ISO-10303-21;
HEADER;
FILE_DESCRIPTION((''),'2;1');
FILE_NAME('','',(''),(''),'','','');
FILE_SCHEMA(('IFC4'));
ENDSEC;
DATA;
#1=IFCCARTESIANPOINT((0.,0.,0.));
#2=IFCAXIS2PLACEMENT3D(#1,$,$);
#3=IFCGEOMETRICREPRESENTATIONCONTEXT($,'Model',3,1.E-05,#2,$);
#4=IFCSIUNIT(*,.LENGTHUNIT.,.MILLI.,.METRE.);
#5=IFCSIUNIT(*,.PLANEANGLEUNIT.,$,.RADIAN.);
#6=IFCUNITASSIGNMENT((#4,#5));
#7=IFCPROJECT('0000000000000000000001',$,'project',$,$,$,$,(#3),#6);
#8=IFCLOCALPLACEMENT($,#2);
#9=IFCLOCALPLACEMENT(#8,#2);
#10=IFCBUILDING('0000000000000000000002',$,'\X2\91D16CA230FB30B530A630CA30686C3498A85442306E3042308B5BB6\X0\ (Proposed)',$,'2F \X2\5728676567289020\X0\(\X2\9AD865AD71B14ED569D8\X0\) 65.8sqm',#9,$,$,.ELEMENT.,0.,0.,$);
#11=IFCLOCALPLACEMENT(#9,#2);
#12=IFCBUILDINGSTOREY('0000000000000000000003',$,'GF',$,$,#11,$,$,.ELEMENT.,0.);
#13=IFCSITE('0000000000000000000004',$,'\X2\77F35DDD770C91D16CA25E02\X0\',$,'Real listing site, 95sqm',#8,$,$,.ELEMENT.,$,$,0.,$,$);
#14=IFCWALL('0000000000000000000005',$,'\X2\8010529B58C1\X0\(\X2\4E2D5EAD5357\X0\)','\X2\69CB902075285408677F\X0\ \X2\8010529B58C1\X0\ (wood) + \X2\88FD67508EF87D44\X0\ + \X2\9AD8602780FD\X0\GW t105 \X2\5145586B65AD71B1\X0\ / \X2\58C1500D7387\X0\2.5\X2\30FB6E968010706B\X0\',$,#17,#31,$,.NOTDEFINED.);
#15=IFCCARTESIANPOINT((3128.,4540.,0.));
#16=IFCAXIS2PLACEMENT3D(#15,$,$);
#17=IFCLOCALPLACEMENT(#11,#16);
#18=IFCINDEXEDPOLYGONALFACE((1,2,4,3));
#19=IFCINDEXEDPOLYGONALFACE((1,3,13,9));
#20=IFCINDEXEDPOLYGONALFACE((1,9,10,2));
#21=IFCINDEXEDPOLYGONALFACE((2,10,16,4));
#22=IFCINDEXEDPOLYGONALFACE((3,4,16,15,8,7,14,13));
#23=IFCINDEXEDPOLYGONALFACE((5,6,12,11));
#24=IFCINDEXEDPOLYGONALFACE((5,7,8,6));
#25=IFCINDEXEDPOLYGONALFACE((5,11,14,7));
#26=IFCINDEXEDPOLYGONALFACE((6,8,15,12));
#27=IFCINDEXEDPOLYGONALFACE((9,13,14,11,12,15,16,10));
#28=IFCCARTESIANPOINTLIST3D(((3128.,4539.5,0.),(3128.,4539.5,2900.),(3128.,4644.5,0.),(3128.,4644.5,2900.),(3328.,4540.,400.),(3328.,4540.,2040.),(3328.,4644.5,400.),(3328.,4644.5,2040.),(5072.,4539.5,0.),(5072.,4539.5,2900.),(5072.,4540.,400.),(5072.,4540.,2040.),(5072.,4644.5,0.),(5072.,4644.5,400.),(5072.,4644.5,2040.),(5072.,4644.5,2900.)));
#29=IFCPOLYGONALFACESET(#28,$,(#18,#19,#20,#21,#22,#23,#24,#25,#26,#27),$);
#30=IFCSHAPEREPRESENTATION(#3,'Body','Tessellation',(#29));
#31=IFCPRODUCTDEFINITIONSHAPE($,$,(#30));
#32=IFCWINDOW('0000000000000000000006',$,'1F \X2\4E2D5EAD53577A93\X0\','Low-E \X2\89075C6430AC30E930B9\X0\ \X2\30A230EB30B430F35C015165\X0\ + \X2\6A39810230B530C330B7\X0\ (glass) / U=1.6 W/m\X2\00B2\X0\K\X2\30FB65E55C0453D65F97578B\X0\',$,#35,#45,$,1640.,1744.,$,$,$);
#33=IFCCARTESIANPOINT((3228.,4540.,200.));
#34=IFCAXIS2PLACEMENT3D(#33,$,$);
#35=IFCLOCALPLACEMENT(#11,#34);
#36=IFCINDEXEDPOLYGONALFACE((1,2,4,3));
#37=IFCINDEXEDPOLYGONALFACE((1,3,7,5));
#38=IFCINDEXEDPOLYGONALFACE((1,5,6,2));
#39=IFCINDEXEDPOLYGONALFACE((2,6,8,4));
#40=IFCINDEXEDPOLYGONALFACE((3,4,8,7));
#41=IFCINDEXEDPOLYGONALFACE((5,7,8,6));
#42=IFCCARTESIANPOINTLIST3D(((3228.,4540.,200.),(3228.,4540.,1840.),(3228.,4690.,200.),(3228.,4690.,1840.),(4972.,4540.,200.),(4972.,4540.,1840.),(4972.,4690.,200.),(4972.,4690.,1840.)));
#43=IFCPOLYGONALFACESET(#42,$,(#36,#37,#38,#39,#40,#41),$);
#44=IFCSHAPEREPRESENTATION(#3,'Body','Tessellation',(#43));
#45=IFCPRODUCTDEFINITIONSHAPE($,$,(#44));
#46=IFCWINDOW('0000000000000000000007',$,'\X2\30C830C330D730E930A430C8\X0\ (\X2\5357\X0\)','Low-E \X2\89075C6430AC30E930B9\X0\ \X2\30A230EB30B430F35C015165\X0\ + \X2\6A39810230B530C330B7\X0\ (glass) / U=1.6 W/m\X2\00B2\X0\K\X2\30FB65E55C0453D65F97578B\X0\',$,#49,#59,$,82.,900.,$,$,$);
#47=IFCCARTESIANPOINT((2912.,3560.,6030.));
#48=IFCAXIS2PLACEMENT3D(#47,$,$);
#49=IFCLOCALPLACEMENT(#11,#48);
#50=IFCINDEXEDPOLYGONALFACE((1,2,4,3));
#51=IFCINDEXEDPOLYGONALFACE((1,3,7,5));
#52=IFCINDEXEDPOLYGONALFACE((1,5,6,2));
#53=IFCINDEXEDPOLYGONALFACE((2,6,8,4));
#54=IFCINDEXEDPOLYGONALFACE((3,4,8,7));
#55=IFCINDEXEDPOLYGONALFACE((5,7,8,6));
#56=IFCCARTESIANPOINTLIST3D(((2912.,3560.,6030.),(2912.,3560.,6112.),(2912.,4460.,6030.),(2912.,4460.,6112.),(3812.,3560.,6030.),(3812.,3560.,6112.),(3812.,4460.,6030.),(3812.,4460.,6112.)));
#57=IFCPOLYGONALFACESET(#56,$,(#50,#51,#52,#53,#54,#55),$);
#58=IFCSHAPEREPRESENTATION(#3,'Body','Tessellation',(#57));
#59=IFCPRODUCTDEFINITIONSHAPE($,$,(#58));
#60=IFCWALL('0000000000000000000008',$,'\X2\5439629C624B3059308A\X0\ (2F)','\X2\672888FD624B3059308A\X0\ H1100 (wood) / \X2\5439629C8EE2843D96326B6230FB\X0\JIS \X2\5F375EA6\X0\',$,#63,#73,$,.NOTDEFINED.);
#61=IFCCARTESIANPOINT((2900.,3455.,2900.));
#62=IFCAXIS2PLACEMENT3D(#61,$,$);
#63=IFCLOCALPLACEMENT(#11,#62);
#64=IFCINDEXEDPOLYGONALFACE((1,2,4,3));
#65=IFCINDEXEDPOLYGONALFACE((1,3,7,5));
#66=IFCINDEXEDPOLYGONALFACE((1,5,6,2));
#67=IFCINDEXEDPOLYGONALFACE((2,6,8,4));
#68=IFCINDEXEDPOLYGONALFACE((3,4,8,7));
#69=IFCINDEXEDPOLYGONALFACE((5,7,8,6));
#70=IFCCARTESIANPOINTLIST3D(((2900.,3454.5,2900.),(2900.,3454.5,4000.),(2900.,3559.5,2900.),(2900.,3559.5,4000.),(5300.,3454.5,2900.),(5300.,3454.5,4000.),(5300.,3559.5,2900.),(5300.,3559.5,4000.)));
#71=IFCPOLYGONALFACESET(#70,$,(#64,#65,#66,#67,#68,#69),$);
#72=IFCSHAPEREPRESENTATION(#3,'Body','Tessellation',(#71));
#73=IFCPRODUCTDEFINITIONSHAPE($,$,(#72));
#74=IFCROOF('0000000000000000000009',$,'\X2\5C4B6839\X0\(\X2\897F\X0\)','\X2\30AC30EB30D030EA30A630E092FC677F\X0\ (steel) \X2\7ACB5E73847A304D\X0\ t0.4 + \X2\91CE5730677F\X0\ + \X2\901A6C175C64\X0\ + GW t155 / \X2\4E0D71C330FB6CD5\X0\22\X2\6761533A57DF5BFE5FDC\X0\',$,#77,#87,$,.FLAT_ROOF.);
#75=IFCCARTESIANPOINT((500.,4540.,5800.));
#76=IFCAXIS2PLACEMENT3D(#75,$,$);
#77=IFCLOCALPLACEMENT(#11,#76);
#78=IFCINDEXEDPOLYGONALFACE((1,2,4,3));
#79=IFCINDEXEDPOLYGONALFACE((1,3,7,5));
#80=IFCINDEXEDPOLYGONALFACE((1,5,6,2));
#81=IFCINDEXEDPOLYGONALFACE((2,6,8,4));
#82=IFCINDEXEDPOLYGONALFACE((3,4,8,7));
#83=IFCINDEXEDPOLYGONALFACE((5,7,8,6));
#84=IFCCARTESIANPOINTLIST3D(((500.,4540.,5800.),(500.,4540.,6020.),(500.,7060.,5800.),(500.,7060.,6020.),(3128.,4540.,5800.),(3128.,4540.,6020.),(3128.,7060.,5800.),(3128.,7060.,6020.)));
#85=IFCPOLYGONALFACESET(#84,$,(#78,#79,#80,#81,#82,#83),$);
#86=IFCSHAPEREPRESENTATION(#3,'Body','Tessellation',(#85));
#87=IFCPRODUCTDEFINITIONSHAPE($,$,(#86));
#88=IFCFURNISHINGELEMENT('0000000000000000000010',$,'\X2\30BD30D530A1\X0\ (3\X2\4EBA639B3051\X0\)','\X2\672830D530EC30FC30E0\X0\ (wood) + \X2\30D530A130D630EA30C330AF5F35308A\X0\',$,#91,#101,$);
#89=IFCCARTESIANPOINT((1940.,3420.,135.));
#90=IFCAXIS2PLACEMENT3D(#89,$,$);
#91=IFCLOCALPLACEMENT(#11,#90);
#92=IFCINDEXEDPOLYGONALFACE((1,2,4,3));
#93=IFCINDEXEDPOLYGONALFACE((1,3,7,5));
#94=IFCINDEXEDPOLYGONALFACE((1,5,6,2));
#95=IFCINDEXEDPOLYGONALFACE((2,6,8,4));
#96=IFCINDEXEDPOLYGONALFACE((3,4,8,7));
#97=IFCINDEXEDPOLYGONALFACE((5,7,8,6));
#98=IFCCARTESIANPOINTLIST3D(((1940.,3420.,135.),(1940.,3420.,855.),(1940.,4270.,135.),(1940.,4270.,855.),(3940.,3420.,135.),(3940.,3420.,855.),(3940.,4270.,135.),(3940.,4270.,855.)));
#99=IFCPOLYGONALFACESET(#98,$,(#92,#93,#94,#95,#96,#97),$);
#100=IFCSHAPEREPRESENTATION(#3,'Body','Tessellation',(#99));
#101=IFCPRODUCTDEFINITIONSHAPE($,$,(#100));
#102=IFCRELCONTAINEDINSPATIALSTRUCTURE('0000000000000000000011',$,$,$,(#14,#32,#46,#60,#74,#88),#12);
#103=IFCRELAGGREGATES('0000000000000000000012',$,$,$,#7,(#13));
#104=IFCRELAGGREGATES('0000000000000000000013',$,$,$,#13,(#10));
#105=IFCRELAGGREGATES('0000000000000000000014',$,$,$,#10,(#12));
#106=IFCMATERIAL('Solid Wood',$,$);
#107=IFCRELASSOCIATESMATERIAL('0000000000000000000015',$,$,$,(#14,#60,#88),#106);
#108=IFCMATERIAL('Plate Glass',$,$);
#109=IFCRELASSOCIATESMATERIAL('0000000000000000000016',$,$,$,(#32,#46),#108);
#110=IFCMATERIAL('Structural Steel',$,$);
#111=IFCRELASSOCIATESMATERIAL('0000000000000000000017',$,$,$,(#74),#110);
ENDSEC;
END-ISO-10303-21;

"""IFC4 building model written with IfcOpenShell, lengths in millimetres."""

from ifc_helpers import new_model, si_unit, frame, frame_2d, origin, place, context, project, spatial, rectangle, extrude, material, element, fill, save


model = new_model("IFC4")

# Units and contexts
model_context = context("Model", 3, precision=1e-05, world=origin())
ifc_project = project(units=[si_unit("LENGTHUNIT", "METRE", prefix="MILLI"), si_unit("PLANEANGLEUNIT", "RADIAN")], contexts=[model_context])

# Site, building, storey
site_placement = place(None, origin())
site = spatial("IfcSite", under=ifc_project, at=site_placement, Name="石川県金沢市", ObjectType="Real listing site, 95sqm", CompositionType="ELEMENT", RefElevation=0.0)
building_placement = place(site_placement, origin())
building = spatial("IfcBuilding", under=site, at=building_placement, Name="金沢・サウナと水風呂のある家 (Proposed)", ObjectType="2F 在来木造(高断熱仕様) 65.8sqm", CompositionType="ELEMENT", ElevationOfRefHeight=0.0, ElevationOfTerrain=0.0)
storey_placement = place(building_placement, origin())
storey = spatial("IfcBuildingStorey", under=building, at=storey_placement, Name="GF", CompositionType="ELEMENT", Elevation=0.0)

# Shared definitions
ifc_material_1 = material(Name="Solid Wood")

# Wall, opening, window
wall_1_placement = place(storey_placement, frame((3128.0, 4540.0, 0.0)))
wall_1 = element("IfcWall", 1, at=wall_1_placement, inside=storey, material=ifc_material_1, Name="耐力壁(中庭南)", Description="構造用合板 耐力壁 (wood) + 製材軸組 + 高性能GW t105 充填断熱 / 壁倍率2.5・準耐火", PredefinedType="NOTDEFINED", context=model_context, shape_type="SweptSolid", body=[
    extrude(rectangle(XDim=1944.0, YDim=105.0, at=frame_2d((972.0, 52.0))), frame((3128.0, 4540.0, 0.0)), (0.0, 0.0, 1.0), 2900.0),
])
opening_placement = place(storey_placement, frame((3228.0, 4540.0, 200.0)))
opening = element("IfcOpeningElement", 2, at=opening_placement, cuts=wall_1, PredefinedType="NOTDEFINED", context=model_context, shape_type="SweptSolid", body=[
    extrude(rectangle(XDim=1744.0, YDim=150.0, at=frame_2d((872.0, 75.0))), frame((3228.0, 4540.0, 200.0)), (0.0, 0.0, 1.0), 1640.0),
])
ifc_material_2 = material(Name="Plate Glass")
window_1_placement = place(storey_placement, frame((3228.0, 4540.0, 200.0)))
window_1 = element("IfcWindow", 3, at=window_1_placement, inside=storey, material=ifc_material_2, Name="1F 中庭南窓", Description="Low-E 複層ガラス アルゴン封入 + 樹脂サッシ (glass) / U=1.6 W/m²K・日射取得型", OverallHeight=1640.0, OverallWidth=1744.0, context=model_context, shape_type="SweptSolid", body=[
    extrude(rectangle(XDim=1744.0, YDim=150.0, at=frame_2d((872.0, 75.0))), frame((3228.0, 4540.0, 200.0)), (0.0, 0.0, 1.0), 1640.0),
])
fill(opening, window_1)

# Window
window_2_placement = place(storey_placement, frame((2912.0, 3560.0, 6030.0)))
element("IfcWindow", 4, at=window_2_placement, inside=storey, material=ifc_material_2, Name="トップライト (南)", Description="Low-E 複層ガラス アルゴン封入 + 樹脂サッシ (glass) / U=1.6 W/m²K・日射取得型", OverallHeight=82.0, OverallWidth=900.0, context=model_context, shape_type="SweptSolid", body=[
    extrude(rectangle(XDim=900.0, YDim=900.0, at=frame_2d((450.0, 450.0))), frame((2912.0, 3560.0, 6030.0)), (0.0, 0.0, 1.0), 82.0),
])

# Wall
wall_2_placement = place(storey_placement, frame((2900.0, 3455.0, 2900.0)))
element("IfcWall", 5, at=wall_2_placement, inside=storey, material=ifc_material_1, Name="吹抜手すり (2F)", Description="木製手すり H1100 (wood) / 吹抜転落防止・JIS 強度", PredefinedType="NOTDEFINED", context=model_context, shape_type="SweptSolid", body=[
    extrude(rectangle(XDim=2400.0, YDim=105.0, at=frame_2d((1200.0, 52.0))), frame((2900.0, 3455.0, 2900.0)), (0.0, 0.0, 1.0), 1100.0),
])

# Roof
ifc_material_3 = material(Name="Structural Steel")
for number, where, name in (
    (6, (500.0, 4540.0, 5800.0), "屋根(西)"),
):
    element("IfcRoof", number, at=place(storey_placement, frame(where)), inside=storey, material=ifc_material_3, Name=name, Description="ガルバリウム鋼板 (steel) 立平葺き t0.4 + 野地板 + 通気層 + GW t155 / 不燃・法22条区域対応", PredefinedType="FLAT_ROOF", context=model_context, shape_type="SweptSolid", body=[
        extrude(rectangle(XDim=2628.0, YDim=2520.0, at=frame_2d((1314.0, 1260.0))), frame((500.0, 4540.0, 5800.0)), (0.0, 0.0, 1.0), 220.0),
    ])

# Furnishing element
furnishing_placement = place(storey_placement, frame((1940.0, 3420.0, 135.0)))
element("IfcFurnishingElement", 7, at=furnishing_placement, inside=storey, material=ifc_material_1, Name="ソファ (3人掛け)", Description="木フレーム (wood) + ファブリック張り", context=model_context, shape_type="SweptSolid", body=[
    extrude(rectangle(XDim=2000.0, YDim=850.0, at=frame_2d((1000.0, 425.0))), frame((1940.0, 3420.0, 135.0)), (0.0, 0.0, 1.0), 720.0),
])

save(model, "model.ifc")
